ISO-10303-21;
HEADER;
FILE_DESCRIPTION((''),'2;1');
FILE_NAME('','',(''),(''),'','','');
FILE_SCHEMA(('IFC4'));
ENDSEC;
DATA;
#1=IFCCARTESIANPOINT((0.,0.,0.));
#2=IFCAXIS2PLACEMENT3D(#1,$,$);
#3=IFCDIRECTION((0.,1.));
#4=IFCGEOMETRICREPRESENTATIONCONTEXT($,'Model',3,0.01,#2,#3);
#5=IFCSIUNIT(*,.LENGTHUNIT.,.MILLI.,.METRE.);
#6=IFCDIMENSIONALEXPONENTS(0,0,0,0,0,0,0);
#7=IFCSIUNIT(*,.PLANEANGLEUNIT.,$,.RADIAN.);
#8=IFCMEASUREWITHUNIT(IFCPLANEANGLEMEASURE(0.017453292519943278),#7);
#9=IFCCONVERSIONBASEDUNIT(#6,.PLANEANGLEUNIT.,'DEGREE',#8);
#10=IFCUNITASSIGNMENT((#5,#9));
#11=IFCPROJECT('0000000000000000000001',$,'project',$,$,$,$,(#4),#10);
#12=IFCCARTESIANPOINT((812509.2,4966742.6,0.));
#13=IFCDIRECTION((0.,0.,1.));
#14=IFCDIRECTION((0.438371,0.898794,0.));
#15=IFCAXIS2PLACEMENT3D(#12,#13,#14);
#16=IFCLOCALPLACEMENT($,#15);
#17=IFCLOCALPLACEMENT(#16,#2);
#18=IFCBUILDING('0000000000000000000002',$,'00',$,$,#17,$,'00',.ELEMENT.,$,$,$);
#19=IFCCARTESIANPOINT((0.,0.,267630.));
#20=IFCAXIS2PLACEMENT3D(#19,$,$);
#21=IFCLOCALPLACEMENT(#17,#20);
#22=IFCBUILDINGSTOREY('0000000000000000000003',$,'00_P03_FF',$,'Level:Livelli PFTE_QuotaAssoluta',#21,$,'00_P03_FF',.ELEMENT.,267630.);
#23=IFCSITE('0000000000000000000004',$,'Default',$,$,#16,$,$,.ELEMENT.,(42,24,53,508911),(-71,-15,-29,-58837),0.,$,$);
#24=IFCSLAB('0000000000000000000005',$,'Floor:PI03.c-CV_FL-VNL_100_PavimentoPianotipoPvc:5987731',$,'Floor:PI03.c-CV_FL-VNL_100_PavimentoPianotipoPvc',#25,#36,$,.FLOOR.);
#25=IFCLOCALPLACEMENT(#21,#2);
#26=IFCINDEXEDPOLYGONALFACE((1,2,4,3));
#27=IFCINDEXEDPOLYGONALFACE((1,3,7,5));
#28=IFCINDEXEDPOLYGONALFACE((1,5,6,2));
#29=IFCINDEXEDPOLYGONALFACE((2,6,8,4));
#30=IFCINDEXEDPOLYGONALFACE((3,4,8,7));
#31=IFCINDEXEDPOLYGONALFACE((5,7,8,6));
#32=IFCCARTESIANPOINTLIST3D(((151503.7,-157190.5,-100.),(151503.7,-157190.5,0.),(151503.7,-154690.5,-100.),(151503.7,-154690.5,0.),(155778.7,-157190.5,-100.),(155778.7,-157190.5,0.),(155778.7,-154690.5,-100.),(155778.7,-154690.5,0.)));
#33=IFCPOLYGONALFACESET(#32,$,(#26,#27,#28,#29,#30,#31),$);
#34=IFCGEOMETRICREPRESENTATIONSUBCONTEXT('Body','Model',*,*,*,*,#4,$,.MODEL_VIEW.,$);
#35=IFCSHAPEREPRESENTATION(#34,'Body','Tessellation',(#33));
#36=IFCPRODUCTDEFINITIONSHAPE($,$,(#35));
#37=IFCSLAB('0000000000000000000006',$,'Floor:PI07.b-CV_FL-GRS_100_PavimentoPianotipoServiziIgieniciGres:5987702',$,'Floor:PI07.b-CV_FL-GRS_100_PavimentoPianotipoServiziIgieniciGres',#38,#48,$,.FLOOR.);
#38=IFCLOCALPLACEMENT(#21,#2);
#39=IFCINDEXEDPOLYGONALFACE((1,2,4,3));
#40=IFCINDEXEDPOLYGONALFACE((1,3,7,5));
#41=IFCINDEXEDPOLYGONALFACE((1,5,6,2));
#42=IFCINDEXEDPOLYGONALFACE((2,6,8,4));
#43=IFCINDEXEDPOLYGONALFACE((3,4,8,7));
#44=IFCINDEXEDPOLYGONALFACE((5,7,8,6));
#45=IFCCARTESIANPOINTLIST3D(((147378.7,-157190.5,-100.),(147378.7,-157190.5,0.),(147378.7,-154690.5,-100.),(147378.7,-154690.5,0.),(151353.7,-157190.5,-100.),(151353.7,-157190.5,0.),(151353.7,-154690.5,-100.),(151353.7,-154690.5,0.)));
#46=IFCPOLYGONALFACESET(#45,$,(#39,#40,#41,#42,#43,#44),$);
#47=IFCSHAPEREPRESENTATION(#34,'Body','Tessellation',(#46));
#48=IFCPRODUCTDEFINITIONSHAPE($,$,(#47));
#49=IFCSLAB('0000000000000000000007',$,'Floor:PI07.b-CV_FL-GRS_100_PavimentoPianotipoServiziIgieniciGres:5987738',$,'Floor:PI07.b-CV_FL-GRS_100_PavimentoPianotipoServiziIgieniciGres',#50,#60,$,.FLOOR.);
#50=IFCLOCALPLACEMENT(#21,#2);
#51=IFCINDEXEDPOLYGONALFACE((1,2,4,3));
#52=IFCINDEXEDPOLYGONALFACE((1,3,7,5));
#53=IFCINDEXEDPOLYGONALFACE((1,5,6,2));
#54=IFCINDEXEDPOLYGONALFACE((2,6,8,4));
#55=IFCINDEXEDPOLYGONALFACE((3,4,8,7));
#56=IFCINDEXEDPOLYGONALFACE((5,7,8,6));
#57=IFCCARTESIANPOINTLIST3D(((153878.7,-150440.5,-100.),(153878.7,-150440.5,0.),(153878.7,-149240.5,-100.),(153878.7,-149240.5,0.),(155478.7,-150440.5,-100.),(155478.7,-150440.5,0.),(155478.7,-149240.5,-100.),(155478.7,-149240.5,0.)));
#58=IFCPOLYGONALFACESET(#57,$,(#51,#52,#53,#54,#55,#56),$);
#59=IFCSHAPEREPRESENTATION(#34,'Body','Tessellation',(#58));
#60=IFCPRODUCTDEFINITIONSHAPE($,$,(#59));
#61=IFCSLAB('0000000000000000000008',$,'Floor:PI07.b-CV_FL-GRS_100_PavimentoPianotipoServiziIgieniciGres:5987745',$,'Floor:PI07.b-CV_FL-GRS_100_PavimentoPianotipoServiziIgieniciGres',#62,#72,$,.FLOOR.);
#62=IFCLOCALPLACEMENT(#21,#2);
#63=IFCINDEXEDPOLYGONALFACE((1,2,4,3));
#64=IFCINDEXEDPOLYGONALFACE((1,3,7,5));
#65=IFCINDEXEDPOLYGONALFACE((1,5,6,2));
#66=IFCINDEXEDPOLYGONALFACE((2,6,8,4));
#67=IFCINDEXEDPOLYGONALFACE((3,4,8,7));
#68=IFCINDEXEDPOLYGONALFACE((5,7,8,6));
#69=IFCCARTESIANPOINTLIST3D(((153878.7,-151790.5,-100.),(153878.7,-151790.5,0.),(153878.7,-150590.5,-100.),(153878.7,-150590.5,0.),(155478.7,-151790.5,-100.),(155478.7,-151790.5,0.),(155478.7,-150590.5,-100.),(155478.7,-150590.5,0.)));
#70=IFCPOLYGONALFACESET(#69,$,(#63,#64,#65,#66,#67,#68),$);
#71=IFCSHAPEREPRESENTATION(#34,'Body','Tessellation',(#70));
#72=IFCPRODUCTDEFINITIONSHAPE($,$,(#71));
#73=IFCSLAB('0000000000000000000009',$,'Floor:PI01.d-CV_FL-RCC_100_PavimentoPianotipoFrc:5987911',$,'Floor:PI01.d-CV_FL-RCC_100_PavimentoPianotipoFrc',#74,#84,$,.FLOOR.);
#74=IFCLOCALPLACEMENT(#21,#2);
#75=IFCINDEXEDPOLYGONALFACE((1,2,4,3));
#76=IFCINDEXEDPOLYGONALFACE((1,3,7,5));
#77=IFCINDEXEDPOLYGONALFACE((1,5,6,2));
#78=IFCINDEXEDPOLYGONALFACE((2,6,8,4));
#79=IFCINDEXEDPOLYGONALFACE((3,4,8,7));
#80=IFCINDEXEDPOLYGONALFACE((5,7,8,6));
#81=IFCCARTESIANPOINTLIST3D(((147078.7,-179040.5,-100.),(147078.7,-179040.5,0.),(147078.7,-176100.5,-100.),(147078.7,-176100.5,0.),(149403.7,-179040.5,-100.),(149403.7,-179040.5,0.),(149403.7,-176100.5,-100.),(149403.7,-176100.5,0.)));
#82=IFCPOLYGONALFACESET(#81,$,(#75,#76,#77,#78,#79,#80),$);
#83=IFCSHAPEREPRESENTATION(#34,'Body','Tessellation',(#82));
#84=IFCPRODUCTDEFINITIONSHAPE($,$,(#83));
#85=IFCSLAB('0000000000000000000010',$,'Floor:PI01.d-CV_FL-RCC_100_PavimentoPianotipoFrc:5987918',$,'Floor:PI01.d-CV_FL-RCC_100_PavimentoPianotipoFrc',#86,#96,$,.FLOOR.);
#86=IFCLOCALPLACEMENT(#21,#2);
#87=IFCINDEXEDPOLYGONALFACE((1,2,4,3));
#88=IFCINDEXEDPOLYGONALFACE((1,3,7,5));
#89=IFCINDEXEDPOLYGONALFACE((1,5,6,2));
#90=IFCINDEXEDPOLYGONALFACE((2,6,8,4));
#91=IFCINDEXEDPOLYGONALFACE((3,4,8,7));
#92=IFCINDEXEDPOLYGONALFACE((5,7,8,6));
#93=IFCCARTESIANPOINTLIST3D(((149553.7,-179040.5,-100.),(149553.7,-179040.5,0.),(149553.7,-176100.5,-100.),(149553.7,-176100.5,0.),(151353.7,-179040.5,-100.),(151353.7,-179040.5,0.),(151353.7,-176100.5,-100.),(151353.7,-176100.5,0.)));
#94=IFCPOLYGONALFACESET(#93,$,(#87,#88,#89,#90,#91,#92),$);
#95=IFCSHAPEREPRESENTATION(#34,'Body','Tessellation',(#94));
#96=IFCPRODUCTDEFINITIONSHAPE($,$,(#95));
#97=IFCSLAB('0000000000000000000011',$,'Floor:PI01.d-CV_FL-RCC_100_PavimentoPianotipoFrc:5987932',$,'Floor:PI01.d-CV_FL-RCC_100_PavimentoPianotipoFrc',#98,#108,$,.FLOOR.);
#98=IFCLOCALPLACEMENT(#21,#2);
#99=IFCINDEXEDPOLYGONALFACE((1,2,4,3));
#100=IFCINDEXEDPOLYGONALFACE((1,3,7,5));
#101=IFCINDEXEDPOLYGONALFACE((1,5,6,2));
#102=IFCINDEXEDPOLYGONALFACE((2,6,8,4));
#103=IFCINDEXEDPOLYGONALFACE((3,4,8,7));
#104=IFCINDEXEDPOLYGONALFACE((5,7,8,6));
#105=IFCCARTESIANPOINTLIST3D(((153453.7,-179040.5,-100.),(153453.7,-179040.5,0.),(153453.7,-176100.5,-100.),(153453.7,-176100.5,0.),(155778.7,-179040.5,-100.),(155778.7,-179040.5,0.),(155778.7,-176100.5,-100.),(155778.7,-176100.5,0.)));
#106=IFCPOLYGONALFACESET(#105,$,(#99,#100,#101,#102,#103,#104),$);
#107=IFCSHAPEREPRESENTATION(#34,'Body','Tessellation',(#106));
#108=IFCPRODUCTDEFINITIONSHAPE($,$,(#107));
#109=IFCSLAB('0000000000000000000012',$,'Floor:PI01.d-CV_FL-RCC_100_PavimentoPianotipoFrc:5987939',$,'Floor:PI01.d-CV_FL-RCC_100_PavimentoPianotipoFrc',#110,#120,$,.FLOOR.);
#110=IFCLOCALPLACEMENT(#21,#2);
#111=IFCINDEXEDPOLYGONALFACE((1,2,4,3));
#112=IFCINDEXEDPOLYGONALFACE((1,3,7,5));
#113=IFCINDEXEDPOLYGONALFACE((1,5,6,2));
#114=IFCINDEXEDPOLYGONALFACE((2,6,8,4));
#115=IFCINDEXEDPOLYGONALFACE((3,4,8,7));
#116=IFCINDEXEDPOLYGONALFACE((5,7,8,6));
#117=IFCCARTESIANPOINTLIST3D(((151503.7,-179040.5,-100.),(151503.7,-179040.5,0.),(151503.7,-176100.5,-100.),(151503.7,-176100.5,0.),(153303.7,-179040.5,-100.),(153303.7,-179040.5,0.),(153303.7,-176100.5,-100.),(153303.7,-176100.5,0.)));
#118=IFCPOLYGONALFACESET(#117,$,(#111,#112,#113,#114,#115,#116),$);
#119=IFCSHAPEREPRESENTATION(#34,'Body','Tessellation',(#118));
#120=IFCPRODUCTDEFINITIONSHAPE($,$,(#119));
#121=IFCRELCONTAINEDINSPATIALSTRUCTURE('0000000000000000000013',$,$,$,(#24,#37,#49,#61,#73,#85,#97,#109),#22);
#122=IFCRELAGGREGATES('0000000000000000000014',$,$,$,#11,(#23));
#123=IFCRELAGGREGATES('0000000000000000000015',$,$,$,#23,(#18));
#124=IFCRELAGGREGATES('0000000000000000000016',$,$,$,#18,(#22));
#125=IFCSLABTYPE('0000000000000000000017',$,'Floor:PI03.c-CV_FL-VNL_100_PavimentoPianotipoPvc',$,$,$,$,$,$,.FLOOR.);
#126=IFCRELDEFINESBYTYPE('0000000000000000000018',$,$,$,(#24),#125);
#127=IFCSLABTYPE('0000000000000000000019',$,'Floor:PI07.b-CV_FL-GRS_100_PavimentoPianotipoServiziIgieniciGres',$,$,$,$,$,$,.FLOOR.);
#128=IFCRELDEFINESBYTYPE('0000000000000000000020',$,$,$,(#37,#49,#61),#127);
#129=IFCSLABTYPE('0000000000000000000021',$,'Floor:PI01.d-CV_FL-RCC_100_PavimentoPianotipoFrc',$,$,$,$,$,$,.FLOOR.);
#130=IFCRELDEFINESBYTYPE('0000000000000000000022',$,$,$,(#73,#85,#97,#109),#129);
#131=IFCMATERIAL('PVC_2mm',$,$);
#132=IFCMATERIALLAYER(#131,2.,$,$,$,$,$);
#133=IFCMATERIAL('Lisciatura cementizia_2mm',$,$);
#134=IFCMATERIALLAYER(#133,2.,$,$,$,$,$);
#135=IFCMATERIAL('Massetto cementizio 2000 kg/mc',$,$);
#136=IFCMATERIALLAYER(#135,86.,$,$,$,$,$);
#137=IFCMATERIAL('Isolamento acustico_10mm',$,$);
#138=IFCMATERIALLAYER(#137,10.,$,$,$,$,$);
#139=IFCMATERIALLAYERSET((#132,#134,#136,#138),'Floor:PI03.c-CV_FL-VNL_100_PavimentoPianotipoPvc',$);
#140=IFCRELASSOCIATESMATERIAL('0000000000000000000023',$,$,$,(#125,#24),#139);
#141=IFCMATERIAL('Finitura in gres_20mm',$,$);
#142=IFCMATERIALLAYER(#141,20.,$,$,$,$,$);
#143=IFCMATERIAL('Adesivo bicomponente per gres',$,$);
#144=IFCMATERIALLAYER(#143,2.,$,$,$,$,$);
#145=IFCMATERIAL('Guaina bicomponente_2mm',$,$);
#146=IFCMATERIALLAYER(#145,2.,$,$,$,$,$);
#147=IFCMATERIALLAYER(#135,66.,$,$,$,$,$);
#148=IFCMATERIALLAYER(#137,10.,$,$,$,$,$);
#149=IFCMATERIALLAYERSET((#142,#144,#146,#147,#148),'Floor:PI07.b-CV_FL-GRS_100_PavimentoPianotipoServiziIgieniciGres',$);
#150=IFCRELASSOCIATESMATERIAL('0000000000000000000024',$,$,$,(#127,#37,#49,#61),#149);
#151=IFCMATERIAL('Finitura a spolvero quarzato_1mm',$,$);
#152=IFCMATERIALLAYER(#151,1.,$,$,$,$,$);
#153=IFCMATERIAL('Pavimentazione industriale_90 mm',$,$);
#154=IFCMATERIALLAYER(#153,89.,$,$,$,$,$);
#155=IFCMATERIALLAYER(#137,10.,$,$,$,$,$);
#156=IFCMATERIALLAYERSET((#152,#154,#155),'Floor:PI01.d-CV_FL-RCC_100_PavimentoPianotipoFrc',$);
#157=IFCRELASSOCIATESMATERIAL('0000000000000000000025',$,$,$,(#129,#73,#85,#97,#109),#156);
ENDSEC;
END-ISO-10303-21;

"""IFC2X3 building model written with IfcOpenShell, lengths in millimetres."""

from ifc_helpers import new_model, entity, si_unit, converted_unit, direction, frame, frame_2d, origin, origin_2d_with_axis, place, context, subcontext, project, spatial, rectangle, extrude, material, layer, layer_set, layer_usage, type_object, element, save


model = new_model("IFC2X3")

# Units and contexts
model_context = context("Model", 3, precision=0.01, world=origin(), true_north=direction((0.0, 1.0)))
body_context = subcontext(model_context, "Body", "Model", "MODEL_VIEW")
ifc_project = project(units=[si_unit("LENGTHUNIT", "METRE", prefix="MILLI"), converted_unit("PLANEANGLEUNIT", "DEGREE", entity("IfcPlaneAngleMeasure", 0.017453292519943278), si_unit("PLANEANGLEUNIT", "RADIAN"), dimensions=[0, 0, 0, 0, 0, 0, 0])], contexts=[model_context])

# Site, building, storey
site_placement = place(None, frame((812509.2, 4966742.6, 0.0), z_axis=(0.0, 0.0, 1.0), x_axis=(0.438371, 0.898794, 0.0)))
site = spatial("IfcSite", under=ifc_project, at=site_placement, Name="Default", CompositionType="ELEMENT", RefLatitude=(42, 24, 53, 508911), RefLongitude=(-71, -15, -29, -58837), RefElevation=0.0)
building_placement = place(site_placement, origin())
building = spatial("IfcBuilding", under=site, at=building_placement, Name="00", LongName="00", CompositionType="ELEMENT")
storey_placement = place(building_placement, frame((0.0, 0.0, 267630.0)))
storey = spatial("IfcBuildingStorey", under=building, at=storey_placement, Name="00_P03_FF", ObjectType="Level:Livelli PFTE_QuotaAssoluta", LongName="00_P03_FF", CompositionType="ELEMENT", Elevation=267630.0)

# Slabs
ifc_material_1 = material(Name="PVC_2mm")
ifc_layer_1 = layer(ifc_material_1, 2.0)
ifc_material_2 = material(Name="Lisciatura cementizia_2mm")
ifc_layer_2 = layer(ifc_material_2, 2.0)
ifc_material_3 = material(Name="Massetto cementizio 2000 kg/mc")
ifc_layer_3 = layer(ifc_material_3, 86.0)
ifc_material_4 = material(Name="Isolamento acustico_10mm")
ifc_layer_4 = layer(ifc_material_4, 10.0)
ifc_layer_set_1 = layer_set([ifc_layer_1, ifc_layer_2, ifc_layer_3, ifc_layer_4], Name="Floor:PI03.c-CV_FL-VNL_100_PavimentoPianotipoPvc")
slab_type_1 = type_object("IfcSlabType", Name="Floor:PI03.c-CV_FL-VNL_100_PavimentoPianotipoPvc", PredefinedType="FLOOR", material=ifc_layer_set_1)
ifc_layer_usage_1 = layer_usage(ifc_layer_set_1, "AXIS3", "POSITIVE", 0.0)
slab_1_placement = place(storey_placement, origin())
element("IfcSlab", 1, at=slab_1_placement, inside=storey, type_object=slab_type_1, material=ifc_layer_usage_1, Name="Floor:PI03.c-CV_FL-VNL_100_PavimentoPianotipoPvc:5987731", ObjectType="Floor:PI03.c-CV_FL-VNL_100_PavimentoPianotipoPvc", PredefinedType="FLOOR", context=body_context, shape_type="SweptSolid", body=[
    extrude(rectangle(XDim=2500.0, YDim=4275.0, at=frame_2d((0.0, 0.0), x_axis=(1.0, 0.0))), frame((153641.2, -155940.5, 0.0), z_axis=(0.0, 0.0, -1.0), x_axis=(0.0, 1.0, 0.0)), (0.0, 0.0, 1.0), 100.0),
])
ifc_material_5 = material(Name="Finitura in gres_20mm")
ifc_layer_5 = layer(ifc_material_5, 20.0)
ifc_material_6 = material(Name="Adesivo bicomponente per gres")
ifc_layer_6 = layer(ifc_material_6, 2.0)
ifc_material_7 = material(Name="Guaina bicomponente_2mm")
ifc_layer_7 = layer(ifc_material_7, 2.0)
ifc_layer_8 = layer(ifc_material_3, 66.0)
ifc_layer_9 = layer(ifc_material_4, 10.0)
ifc_layer_set_2 = layer_set([ifc_layer_5, ifc_layer_6, ifc_layer_7, ifc_layer_8, ifc_layer_9], Name="Floor:PI07.b-CV_FL-GRS_100_PavimentoPianotipoServiziIgieniciGres")
ifc_layer_usage_2 = layer_usage(ifc_layer_set_2, "AXIS3", "POSITIVE", 0.0)
slab_type_2 = type_object("IfcSlabType", Name="Floor:PI07.b-CV_FL-GRS_100_PavimentoPianotipoServiziIgieniciGres", PredefinedType="FLOOR", material=ifc_layer_set_2)
slab_2_placement = place(storey_placement, origin())
element("IfcSlab", 2, at=slab_2_placement, inside=storey, type_object=slab_type_2, material=ifc_layer_usage_2, Name="Floor:PI07.b-CV_FL-GRS_100_PavimentoPianotipoServiziIgieniciGres:5987702", ObjectType="Floor:PI07.b-CV_FL-GRS_100_PavimentoPianotipoServiziIgieniciGres", PredefinedType="FLOOR", context=body_context, shape_type="SweptSolid", body=[
    extrude(rectangle(XDim=2500.0, YDim=3975.0, at=origin_2d_with_axis()), frame((149366.2, -155940.5, 0.0), z_axis=(0.0, 0.0, -1.0), x_axis=(0.0, 1.0, 0.0)), (0.0, 0.0, 1.0), 100.0),
])
ifc_layer_usage_3 = layer_usage(ifc_layer_set_2, "AXIS3", "POSITIVE", 0.0)
slab_3_placement = place(storey_placement, origin())
element("IfcSlab", 3, at=slab_3_placement, inside=storey, type_object=slab_type_2, material=ifc_layer_usage_3, Name="Floor:PI07.b-CV_FL-GRS_100_PavimentoPianotipoServiziIgieniciGres:5987738", ObjectType="Floor:PI07.b-CV_FL-GRS_100_PavimentoPianotipoServiziIgieniciGres", PredefinedType="FLOOR", context=body_context, shape_type="SweptSolid", body=[
    extrude(rectangle(XDim=1200.0, YDim=1600.0, at=frame_2d((0.0, 0.0), x_axis=(1.0, 0.0))), frame((154678.7, -149840.5, 0.0), z_axis=(0.0, 0.0, -1.0), x_axis=(0.0, 1.0, 0.0)), (0.0, 0.0, 1.0), 100.0),
])
ifc_layer_usage_4 = layer_usage(ifc_layer_set_2, "AXIS3", "POSITIVE", 0.0)
slab_4_placement = place(storey_placement, origin())
element("IfcSlab", 4, at=slab_4_placement, inside=storey, type_object=slab_type_2, material=ifc_layer_usage_4, Name="Floor:PI07.b-CV_FL-GRS_100_PavimentoPianotipoServiziIgieniciGres:5987745", ObjectType="Floor:PI07.b-CV_FL-GRS_100_PavimentoPianotipoServiziIgieniciGres", PredefinedType="FLOOR", context=body_context, shape_type="SweptSolid", body=[
    extrude(rectangle(XDim=1200.0, YDim=1600.0, at=frame_2d((0.0, 0.0), x_axis=(1.0, 0.0))), frame((154678.7, -151190.5, 0.0), z_axis=(0.0, 0.0, -1.0), x_axis=(0.0, 1.0, 0.0)), (0.0, 0.0, 1.0), 100.0),
])
ifc_material_8 = material(Name="Finitura a spolvero quarzato_1mm")
ifc_layer_10 = layer(ifc_material_8, 1.0)
ifc_material_9 = material(Name="Pavimentazione industriale_90 mm")
ifc_layer_11 = layer(ifc_material_9, 89.0)
ifc_layer_12 = layer(ifc_material_4, 10.0)
ifc_layer_set_3 = layer_set([ifc_layer_10, ifc_layer_11, ifc_layer_12], Name="Floor:PI01.d-CV_FL-RCC_100_PavimentoPianotipoFrc")
slab_type_3 = type_object("IfcSlabType", Name="Floor:PI01.d-CV_FL-RCC_100_PavimentoPianotipoFrc", PredefinedType="FLOOR", material=ifc_layer_set_3)
ifc_layer_usage_5 = layer_usage(ifc_layer_set_3, "AXIS3", "POSITIVE", 0.0)
slab_5_placement = place(storey_placement, origin())
element("IfcSlab", 5, at=slab_5_placement, inside=storey, type_object=slab_type_3, material=ifc_layer_usage_5, Name="Floor:PI01.d-CV_FL-RCC_100_PavimentoPianotipoFrc:5987911", ObjectType="Floor:PI01.d-CV_FL-RCC_100_PavimentoPianotipoFrc", PredefinedType="FLOOR", context=body_context, shape_type="SweptSolid", body=[
    extrude(rectangle(XDim=2940.0, YDim=2325.0, at=frame_2d((0.0, 0.0), x_axis=(1.0, 0.0))), frame((148241.2, -177570.5, 0.0), z_axis=(0.0, 0.0, -1.0), x_axis=(0.0, 1.0, 0.0)), (0.0, 0.0, 1.0), 100.0),
])
ifc_layer_usage_6 = layer_usage(ifc_layer_set_3, "AXIS3", "POSITIVE", 0.0)
slab_6_placement = place(storey_placement, origin())
element("IfcSlab", 6, at=slab_6_placement, inside=storey, type_object=slab_type_3, material=ifc_layer_usage_6, Name="Floor:PI01.d-CV_FL-RCC_100_PavimentoPianotipoFrc:5987918", ObjectType="Floor:PI01.d-CV_FL-RCC_100_PavimentoPianotipoFrc", PredefinedType="FLOOR", context=body_context, shape_type="SweptSolid", body=[
    extrude(rectangle(XDim=2940.0, YDim=1800.0, at=frame_2d((0.0, 0.0), x_axis=(1.0, 0.0))), frame((150453.7, -177570.5, 0.0), z_axis=(0.0, 0.0, -1.0), x_axis=(0.0, 1.0, 0.0)), (0.0, 0.0, 1.0), 100.0),
])
ifc_layer_usage_7 = layer_usage(ifc_layer_set_3, "AXIS3", "POSITIVE", 0.0)
slab_7_placement = place(storey_placement, origin())
element("IfcSlab", 7, at=slab_7_placement, inside=storey, type_object=slab_type_3, material=ifc_layer_usage_7, Name="Floor:PI01.d-CV_FL-RCC_100_PavimentoPianotipoFrc:5987932", ObjectType="Floor:PI01.d-CV_FL-RCC_100_PavimentoPianotipoFrc", PredefinedType="FLOOR", context=body_context, shape_type="SweptSolid", body=[
    extrude(rectangle(XDim=2940.0, YDim=2325.0, at=origin_2d_with_axis()), frame((154616.2, -177570.5, 0.0), z_axis=(0.0, 0.0, -1.0), x_axis=(0.0, 1.0, 0.0)), (0.0, 0.0, 1.0), 100.0),
])
ifc_layer_usage_8 = layer_usage(ifc_layer_set_3, "AXIS3", "POSITIVE", 0.0)
slab_8_placement = place(storey_placement, origin())
element("IfcSlab", 8, at=slab_8_placement, inside=storey, type_object=slab_type_3, material=ifc_layer_usage_8, Name="Floor:PI01.d-CV_FL-RCC_100_PavimentoPianotipoFrc:5987939", ObjectType="Floor:PI01.d-CV_FL-RCC_100_PavimentoPianotipoFrc", PredefinedType="FLOOR", context=body_context, shape_type="SweptSolid", body=[
    extrude(rectangle(XDim=2940.0, YDim=1800.0, at=frame_2d((0.0, 0.0), x_axis=(1.0, 0.0))), frame((152403.7, -177570.5, 0.0), z_axis=(0.0, 0.0, -1.0), x_axis=(0.0, 1.0, 0.0)), (0.0, 0.0, 1.0), 100.0),
])

save(model, "model.ifc")
